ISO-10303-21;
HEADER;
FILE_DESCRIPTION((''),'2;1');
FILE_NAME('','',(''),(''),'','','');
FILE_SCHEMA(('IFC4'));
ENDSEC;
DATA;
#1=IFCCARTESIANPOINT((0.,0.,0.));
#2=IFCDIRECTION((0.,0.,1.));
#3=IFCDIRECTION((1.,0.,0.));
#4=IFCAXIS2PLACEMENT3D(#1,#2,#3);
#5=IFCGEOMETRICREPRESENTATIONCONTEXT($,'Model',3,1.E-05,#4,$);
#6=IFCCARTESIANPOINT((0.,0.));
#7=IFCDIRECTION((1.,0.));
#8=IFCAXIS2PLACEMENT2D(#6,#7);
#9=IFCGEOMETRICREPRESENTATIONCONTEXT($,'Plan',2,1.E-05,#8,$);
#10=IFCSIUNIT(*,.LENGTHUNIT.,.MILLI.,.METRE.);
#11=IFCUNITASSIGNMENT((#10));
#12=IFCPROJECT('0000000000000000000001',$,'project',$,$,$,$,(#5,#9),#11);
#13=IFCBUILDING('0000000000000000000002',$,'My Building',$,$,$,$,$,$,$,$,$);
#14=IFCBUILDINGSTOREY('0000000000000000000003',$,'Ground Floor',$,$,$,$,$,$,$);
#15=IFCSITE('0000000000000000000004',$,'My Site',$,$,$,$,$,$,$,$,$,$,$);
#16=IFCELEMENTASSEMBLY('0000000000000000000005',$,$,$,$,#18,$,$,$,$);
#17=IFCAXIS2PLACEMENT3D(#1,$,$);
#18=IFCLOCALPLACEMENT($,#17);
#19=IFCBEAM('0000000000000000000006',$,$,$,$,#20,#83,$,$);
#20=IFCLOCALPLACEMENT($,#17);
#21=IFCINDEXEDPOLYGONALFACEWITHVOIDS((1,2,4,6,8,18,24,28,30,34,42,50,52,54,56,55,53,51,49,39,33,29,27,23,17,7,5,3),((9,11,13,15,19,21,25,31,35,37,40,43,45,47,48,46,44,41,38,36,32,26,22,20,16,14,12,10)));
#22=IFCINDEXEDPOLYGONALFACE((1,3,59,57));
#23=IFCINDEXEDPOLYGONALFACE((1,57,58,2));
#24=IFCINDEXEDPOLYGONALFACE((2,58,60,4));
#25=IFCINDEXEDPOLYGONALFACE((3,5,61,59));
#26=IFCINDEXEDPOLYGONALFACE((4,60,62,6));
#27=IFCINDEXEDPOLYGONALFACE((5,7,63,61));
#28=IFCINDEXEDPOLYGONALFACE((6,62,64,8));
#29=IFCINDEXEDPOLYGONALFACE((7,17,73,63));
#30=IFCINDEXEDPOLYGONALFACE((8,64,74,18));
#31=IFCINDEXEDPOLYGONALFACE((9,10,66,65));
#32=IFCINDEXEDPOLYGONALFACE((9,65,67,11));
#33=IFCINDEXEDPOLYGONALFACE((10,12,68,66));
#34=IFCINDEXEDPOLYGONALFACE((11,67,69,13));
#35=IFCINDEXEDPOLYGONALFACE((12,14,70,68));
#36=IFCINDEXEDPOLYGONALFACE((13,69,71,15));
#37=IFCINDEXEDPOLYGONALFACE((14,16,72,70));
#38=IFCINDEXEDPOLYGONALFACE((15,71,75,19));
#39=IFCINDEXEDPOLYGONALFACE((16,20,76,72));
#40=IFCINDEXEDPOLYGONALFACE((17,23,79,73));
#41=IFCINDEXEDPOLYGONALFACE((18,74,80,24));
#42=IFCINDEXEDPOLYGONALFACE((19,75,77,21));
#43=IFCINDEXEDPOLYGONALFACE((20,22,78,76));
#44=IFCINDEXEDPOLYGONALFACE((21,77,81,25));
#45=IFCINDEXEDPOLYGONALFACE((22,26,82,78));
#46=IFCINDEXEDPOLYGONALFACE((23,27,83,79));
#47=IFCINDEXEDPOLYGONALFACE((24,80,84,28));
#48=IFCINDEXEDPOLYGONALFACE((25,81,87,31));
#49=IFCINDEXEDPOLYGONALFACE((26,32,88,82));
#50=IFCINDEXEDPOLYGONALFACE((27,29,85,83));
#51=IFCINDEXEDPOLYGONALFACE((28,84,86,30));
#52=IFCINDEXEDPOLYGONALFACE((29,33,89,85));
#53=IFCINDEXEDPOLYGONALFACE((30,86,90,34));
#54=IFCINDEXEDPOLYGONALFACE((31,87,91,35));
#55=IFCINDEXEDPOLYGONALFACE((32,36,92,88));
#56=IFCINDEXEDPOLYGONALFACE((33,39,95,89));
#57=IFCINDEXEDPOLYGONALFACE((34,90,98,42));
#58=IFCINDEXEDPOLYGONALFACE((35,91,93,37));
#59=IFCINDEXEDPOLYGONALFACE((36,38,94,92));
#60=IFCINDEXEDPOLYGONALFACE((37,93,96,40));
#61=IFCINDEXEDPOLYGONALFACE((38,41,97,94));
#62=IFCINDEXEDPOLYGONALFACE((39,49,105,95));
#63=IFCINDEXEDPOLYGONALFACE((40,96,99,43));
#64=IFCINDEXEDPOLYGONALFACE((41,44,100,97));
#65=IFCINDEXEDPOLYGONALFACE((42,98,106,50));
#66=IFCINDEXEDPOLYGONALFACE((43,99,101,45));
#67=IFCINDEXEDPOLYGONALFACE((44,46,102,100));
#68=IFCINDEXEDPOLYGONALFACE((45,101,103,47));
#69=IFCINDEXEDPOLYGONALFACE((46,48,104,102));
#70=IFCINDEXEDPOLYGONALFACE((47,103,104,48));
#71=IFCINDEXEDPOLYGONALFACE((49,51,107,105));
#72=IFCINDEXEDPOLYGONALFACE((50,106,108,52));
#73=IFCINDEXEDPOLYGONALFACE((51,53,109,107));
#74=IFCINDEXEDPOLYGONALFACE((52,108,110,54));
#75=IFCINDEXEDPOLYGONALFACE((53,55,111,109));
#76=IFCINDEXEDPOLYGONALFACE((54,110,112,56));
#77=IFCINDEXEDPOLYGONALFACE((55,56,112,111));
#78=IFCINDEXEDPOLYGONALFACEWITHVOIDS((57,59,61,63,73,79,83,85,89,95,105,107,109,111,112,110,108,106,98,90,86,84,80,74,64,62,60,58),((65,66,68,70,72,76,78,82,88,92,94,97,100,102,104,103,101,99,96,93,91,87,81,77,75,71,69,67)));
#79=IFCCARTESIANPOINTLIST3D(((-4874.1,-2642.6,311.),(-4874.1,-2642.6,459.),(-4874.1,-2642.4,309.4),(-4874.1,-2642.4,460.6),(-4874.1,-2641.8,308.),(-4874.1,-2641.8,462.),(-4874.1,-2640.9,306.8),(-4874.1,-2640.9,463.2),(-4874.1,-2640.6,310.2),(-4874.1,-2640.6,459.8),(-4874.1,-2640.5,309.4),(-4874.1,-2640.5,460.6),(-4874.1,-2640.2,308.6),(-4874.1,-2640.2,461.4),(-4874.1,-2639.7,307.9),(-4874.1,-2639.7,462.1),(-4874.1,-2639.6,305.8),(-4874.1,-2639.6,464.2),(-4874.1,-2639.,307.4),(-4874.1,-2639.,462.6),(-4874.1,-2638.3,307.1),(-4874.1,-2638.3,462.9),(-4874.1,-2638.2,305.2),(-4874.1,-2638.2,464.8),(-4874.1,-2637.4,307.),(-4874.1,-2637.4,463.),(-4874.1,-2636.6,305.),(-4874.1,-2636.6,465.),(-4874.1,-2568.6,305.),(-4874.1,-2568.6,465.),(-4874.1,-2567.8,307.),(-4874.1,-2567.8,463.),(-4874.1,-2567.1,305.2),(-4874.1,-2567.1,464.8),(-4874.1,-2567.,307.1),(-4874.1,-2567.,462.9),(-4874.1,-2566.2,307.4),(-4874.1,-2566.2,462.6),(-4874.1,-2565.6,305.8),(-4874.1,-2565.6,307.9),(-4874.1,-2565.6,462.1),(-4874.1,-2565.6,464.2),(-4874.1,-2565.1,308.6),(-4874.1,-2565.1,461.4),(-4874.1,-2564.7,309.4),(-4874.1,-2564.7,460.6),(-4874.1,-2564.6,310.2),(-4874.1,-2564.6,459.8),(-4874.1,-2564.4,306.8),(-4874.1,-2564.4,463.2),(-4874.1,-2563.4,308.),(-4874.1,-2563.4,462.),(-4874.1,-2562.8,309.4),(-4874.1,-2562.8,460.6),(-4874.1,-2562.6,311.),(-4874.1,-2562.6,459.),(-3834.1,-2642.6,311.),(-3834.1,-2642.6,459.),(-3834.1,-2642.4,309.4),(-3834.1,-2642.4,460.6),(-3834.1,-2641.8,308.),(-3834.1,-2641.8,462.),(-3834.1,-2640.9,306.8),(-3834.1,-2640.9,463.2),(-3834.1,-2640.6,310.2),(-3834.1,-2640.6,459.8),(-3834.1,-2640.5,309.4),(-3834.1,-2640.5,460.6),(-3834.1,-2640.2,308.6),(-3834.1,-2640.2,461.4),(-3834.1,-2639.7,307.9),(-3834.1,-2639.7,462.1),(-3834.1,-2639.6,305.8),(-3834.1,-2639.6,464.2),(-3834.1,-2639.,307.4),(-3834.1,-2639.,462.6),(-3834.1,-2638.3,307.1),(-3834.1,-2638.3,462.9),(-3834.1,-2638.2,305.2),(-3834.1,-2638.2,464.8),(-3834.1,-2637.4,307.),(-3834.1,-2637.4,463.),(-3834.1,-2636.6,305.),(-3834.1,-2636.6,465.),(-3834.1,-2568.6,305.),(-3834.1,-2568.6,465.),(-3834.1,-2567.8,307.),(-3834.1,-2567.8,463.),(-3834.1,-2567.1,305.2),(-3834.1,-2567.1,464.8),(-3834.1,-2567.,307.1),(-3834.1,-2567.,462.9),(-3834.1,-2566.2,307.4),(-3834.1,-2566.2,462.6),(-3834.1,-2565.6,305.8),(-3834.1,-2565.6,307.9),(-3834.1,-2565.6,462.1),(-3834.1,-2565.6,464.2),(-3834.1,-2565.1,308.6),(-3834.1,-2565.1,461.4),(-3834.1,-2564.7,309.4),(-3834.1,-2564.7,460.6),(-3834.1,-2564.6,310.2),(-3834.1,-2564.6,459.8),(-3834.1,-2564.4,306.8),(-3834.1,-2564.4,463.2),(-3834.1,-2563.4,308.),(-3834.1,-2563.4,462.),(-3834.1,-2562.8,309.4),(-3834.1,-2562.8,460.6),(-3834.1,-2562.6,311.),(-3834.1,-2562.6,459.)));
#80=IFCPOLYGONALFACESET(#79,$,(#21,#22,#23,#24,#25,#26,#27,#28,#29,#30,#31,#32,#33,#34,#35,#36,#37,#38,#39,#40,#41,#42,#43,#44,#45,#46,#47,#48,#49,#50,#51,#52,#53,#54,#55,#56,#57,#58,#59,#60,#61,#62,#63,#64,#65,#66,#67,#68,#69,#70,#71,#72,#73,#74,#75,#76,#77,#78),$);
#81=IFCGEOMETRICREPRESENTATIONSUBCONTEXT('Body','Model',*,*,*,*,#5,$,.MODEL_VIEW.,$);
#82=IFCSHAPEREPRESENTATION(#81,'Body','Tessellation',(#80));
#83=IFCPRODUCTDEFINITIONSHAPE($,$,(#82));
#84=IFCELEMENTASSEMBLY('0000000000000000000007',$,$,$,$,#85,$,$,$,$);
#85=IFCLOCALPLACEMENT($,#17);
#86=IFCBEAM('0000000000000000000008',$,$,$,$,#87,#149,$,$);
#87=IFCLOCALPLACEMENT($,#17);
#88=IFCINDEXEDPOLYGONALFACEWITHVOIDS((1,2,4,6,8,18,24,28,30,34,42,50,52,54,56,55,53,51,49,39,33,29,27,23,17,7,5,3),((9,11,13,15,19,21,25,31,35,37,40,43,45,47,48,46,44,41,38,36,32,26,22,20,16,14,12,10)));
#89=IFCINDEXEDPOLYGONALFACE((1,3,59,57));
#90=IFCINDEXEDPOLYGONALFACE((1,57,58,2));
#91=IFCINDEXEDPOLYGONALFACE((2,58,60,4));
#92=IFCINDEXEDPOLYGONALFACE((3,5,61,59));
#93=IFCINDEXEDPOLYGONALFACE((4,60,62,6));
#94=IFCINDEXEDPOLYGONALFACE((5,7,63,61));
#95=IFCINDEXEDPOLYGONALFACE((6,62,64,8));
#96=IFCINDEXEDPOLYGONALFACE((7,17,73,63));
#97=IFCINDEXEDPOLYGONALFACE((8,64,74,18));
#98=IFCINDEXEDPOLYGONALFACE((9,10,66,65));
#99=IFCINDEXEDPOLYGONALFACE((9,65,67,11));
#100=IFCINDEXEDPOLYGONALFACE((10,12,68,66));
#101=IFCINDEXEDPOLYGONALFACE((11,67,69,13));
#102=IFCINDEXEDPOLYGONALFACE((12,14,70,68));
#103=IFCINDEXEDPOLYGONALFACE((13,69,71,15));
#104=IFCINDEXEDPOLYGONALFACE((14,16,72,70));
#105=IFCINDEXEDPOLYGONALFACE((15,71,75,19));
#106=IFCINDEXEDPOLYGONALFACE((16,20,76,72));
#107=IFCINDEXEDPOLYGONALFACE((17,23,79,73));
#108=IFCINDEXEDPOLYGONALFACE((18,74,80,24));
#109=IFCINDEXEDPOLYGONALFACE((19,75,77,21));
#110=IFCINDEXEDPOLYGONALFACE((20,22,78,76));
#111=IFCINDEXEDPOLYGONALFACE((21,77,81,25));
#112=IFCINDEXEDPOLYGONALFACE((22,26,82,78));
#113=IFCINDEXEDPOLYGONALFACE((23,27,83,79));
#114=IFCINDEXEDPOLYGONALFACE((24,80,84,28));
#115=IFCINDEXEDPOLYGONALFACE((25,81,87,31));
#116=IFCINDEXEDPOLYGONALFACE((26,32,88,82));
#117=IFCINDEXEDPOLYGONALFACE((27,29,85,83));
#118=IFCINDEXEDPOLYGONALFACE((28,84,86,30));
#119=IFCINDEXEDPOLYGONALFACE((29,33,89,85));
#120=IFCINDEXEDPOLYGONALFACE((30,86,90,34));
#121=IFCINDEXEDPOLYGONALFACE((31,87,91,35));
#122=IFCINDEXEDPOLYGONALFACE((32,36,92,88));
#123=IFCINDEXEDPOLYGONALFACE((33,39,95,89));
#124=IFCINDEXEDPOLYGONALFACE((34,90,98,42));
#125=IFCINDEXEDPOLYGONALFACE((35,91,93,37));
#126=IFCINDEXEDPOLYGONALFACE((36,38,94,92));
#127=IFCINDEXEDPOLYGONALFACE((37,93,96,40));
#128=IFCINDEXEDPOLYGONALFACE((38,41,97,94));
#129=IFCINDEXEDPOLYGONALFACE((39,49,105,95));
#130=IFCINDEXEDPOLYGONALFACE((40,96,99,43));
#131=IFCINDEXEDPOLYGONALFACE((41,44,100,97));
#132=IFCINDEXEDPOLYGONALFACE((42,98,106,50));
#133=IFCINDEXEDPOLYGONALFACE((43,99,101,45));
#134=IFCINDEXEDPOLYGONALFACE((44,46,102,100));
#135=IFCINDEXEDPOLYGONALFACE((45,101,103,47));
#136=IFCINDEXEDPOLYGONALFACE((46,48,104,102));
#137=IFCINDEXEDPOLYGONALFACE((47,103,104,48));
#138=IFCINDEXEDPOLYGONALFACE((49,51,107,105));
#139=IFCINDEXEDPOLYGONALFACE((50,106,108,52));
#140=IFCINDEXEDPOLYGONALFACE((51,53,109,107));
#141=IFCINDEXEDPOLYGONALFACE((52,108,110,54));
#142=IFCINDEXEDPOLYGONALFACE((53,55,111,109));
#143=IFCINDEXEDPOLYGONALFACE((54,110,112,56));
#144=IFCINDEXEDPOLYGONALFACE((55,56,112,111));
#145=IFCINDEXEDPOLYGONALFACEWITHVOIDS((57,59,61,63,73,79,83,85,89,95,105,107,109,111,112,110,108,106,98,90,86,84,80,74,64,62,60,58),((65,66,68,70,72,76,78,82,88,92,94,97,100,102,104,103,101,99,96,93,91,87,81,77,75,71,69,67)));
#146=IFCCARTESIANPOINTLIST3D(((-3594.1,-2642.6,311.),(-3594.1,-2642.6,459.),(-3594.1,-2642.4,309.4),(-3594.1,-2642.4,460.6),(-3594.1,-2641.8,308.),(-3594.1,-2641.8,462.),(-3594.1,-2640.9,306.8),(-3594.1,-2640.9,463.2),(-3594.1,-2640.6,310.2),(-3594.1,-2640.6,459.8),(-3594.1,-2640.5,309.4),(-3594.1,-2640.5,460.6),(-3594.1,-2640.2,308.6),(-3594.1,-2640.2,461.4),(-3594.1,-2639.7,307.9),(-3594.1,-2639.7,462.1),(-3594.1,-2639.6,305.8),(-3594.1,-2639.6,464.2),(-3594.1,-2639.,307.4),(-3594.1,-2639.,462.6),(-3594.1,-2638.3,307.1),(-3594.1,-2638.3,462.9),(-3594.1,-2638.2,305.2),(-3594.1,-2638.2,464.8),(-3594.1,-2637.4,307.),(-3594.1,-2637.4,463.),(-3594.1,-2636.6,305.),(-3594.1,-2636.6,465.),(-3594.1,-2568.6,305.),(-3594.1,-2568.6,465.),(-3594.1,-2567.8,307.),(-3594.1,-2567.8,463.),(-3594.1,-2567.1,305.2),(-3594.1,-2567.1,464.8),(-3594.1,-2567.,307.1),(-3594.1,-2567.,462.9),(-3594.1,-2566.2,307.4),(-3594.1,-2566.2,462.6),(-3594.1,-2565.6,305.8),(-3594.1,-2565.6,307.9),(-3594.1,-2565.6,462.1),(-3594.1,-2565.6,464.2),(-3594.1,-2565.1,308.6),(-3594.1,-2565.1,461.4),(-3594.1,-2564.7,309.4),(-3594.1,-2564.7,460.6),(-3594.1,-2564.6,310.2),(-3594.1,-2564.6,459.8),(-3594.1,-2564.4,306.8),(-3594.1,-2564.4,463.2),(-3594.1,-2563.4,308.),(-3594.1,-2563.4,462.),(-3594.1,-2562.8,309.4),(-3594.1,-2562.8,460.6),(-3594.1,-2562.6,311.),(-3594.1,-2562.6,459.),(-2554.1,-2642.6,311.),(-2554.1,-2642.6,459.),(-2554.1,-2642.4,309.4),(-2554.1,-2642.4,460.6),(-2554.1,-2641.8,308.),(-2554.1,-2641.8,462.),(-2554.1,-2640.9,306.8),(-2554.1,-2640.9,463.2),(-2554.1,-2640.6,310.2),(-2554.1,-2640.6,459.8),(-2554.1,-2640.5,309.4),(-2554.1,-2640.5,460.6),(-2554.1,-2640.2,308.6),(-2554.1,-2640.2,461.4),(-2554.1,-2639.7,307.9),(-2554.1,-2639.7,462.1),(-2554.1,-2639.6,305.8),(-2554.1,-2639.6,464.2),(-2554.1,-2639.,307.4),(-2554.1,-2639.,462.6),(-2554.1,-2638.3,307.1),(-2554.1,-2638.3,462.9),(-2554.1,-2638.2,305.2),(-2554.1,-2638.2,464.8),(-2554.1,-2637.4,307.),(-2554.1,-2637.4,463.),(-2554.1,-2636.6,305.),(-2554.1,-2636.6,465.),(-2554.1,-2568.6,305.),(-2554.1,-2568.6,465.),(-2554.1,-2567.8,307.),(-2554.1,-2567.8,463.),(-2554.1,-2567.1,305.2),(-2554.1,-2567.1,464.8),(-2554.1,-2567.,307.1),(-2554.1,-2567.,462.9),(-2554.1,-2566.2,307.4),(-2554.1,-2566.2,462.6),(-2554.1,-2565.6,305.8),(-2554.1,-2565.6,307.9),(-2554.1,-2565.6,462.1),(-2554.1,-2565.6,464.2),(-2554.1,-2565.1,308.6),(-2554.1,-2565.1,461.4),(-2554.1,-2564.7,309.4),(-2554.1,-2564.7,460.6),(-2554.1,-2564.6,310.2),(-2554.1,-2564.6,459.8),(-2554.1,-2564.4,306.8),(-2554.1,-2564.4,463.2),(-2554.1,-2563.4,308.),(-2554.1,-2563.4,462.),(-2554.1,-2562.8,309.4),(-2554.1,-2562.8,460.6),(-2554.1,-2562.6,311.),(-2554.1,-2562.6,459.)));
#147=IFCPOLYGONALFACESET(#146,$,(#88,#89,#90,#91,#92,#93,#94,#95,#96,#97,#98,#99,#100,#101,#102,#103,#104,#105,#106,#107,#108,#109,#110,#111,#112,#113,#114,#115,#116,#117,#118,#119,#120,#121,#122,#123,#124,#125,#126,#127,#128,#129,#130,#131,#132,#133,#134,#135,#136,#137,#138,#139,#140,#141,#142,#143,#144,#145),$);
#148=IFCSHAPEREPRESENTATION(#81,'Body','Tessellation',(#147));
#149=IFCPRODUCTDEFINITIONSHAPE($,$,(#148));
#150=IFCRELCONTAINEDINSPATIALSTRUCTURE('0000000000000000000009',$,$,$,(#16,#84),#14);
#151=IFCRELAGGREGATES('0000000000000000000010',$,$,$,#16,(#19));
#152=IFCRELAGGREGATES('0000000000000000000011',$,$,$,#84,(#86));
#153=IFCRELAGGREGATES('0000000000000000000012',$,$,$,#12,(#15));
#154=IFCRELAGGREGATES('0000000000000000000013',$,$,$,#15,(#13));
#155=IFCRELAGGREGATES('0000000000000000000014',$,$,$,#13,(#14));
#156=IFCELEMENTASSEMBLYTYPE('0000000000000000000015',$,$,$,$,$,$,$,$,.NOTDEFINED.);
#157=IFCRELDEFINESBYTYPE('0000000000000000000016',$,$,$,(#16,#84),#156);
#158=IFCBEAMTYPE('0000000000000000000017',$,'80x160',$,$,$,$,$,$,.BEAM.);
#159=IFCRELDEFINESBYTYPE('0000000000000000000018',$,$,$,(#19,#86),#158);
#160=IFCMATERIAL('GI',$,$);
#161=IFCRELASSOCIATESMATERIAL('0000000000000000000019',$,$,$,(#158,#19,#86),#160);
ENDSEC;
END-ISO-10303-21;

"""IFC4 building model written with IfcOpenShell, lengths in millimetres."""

from ifc_helpers import new_model, si_unit, frame, origin_with_axes, origin_2d_with_axis, place, context, subcontext, project, spatial, hollow_rectangle, extrude, material, material_profile, profile_set, profile_usage, type_object, element, aggregate, save


model = new_model("IFC4")

# Units and contexts
model_context = context("Model", 3, precision=1e-05, world=origin_with_axes())
plan_context = context("Plan", 2, precision=1e-05, world=origin_2d_with_axis())
body_context = subcontext(model_context, "Body", "Model", "MODEL_VIEW")
ifc_project = project(units=[si_unit("LENGTHUNIT", "METRE", prefix="MILLI")], contexts=[model_context, plan_context])

# Site, building, storey
site = spatial("IfcSite", under=ifc_project, Name="My Site")
building = spatial("IfcBuilding", under=site, Name="My Building")
storey = spatial("IfcBuildingStorey", under=building, Name="Ground Floor")

# Shared definitions
ifc_material_1 = material(Name="GI")

# Element assemblies, beams
element_assembly_type_1 = type_object("IfcElementAssemblyType", PredefinedType="NOTDEFINED")
ifc_material_profile_1 = material_profile(ifc_material_1, hollow_rectangle(XDim=80.0, YDim=160.0, WallThickness=2.0, InnerFilletRadius=3.2, OuterFilletRadius=6.0))
ifc_profile_set_1 = profile_set([ifc_material_profile_1], Name="80x160 GI Rectangular Hollow")
beam_type = type_object("IfcBeamType", Name="80x160", PredefinedType="BEAM", material=ifc_profile_set_1)
assembly_1_placement = place(None, frame((-4954.1, -2602.6, 385.0), z_axis=(1.0, 0.0, 0.0), x_axis=(0.0, 1.0, 0.0)))
assembly_1 = element("IfcElementAssembly", 1, at=assembly_1_placement, inside=storey, type_object=element_assembly_type_1)
ifc_profile_usage_1 = profile_usage(ifc_profile_set_1)
beam_1_placement = place(assembly_1_placement, frame((0.0, 0.0, 80.0), z_axis=(0.0, 0.0, 1.0), x_axis=(1.0, 0.0, 0.0)))
beam_1 = element("IfcBeam", 2, at=beam_1_placement, type_object=beam_type, material=ifc_profile_usage_1, context=body_context, shape_type="SweptSolid", body=[
    extrude(hollow_rectangle(XDim=80.0, YDim=160.0, WallThickness=2.0, InnerFilletRadius=3.2, OuterFilletRadius=6.0), origin_with_axes(), (0.0, 0.0, 1.0), 1040.0),
])
aggregate(assembly_1, [beam_1])
assembly_2_placement = place(None, frame((-3674.1, -2602.6, 385.0), z_axis=(1.0, 0.0, 0.0), x_axis=(0.0, 1.0, 0.0)))
assembly_2 = element("IfcElementAssembly", 3, at=assembly_2_placement, inside=storey, type_object=element_assembly_type_1)
ifc_profile_usage_2 = profile_usage(ifc_profile_set_1)
beam_2_placement = place(assembly_2_placement, frame((0.0, 0.0, 80.0), z_axis=(0.0, 0.0, 1.0), x_axis=(1.0, 0.0, 0.0)))
beam_2 = element("IfcBeam", 4, at=beam_2_placement, type_object=beam_type, material=ifc_profile_usage_2, context=body_context, shape_type="SweptSolid", body=[
    extrude(hollow_rectangle(XDim=80.0, YDim=160.0, WallThickness=2.0, InnerFilletRadius=3.2, OuterFilletRadius=6.0), origin_with_axes(), (0.0, 0.0, 1.0), 1040.0),
])
aggregate(assembly_2, [beam_2])

save(model, "model.ifc")
